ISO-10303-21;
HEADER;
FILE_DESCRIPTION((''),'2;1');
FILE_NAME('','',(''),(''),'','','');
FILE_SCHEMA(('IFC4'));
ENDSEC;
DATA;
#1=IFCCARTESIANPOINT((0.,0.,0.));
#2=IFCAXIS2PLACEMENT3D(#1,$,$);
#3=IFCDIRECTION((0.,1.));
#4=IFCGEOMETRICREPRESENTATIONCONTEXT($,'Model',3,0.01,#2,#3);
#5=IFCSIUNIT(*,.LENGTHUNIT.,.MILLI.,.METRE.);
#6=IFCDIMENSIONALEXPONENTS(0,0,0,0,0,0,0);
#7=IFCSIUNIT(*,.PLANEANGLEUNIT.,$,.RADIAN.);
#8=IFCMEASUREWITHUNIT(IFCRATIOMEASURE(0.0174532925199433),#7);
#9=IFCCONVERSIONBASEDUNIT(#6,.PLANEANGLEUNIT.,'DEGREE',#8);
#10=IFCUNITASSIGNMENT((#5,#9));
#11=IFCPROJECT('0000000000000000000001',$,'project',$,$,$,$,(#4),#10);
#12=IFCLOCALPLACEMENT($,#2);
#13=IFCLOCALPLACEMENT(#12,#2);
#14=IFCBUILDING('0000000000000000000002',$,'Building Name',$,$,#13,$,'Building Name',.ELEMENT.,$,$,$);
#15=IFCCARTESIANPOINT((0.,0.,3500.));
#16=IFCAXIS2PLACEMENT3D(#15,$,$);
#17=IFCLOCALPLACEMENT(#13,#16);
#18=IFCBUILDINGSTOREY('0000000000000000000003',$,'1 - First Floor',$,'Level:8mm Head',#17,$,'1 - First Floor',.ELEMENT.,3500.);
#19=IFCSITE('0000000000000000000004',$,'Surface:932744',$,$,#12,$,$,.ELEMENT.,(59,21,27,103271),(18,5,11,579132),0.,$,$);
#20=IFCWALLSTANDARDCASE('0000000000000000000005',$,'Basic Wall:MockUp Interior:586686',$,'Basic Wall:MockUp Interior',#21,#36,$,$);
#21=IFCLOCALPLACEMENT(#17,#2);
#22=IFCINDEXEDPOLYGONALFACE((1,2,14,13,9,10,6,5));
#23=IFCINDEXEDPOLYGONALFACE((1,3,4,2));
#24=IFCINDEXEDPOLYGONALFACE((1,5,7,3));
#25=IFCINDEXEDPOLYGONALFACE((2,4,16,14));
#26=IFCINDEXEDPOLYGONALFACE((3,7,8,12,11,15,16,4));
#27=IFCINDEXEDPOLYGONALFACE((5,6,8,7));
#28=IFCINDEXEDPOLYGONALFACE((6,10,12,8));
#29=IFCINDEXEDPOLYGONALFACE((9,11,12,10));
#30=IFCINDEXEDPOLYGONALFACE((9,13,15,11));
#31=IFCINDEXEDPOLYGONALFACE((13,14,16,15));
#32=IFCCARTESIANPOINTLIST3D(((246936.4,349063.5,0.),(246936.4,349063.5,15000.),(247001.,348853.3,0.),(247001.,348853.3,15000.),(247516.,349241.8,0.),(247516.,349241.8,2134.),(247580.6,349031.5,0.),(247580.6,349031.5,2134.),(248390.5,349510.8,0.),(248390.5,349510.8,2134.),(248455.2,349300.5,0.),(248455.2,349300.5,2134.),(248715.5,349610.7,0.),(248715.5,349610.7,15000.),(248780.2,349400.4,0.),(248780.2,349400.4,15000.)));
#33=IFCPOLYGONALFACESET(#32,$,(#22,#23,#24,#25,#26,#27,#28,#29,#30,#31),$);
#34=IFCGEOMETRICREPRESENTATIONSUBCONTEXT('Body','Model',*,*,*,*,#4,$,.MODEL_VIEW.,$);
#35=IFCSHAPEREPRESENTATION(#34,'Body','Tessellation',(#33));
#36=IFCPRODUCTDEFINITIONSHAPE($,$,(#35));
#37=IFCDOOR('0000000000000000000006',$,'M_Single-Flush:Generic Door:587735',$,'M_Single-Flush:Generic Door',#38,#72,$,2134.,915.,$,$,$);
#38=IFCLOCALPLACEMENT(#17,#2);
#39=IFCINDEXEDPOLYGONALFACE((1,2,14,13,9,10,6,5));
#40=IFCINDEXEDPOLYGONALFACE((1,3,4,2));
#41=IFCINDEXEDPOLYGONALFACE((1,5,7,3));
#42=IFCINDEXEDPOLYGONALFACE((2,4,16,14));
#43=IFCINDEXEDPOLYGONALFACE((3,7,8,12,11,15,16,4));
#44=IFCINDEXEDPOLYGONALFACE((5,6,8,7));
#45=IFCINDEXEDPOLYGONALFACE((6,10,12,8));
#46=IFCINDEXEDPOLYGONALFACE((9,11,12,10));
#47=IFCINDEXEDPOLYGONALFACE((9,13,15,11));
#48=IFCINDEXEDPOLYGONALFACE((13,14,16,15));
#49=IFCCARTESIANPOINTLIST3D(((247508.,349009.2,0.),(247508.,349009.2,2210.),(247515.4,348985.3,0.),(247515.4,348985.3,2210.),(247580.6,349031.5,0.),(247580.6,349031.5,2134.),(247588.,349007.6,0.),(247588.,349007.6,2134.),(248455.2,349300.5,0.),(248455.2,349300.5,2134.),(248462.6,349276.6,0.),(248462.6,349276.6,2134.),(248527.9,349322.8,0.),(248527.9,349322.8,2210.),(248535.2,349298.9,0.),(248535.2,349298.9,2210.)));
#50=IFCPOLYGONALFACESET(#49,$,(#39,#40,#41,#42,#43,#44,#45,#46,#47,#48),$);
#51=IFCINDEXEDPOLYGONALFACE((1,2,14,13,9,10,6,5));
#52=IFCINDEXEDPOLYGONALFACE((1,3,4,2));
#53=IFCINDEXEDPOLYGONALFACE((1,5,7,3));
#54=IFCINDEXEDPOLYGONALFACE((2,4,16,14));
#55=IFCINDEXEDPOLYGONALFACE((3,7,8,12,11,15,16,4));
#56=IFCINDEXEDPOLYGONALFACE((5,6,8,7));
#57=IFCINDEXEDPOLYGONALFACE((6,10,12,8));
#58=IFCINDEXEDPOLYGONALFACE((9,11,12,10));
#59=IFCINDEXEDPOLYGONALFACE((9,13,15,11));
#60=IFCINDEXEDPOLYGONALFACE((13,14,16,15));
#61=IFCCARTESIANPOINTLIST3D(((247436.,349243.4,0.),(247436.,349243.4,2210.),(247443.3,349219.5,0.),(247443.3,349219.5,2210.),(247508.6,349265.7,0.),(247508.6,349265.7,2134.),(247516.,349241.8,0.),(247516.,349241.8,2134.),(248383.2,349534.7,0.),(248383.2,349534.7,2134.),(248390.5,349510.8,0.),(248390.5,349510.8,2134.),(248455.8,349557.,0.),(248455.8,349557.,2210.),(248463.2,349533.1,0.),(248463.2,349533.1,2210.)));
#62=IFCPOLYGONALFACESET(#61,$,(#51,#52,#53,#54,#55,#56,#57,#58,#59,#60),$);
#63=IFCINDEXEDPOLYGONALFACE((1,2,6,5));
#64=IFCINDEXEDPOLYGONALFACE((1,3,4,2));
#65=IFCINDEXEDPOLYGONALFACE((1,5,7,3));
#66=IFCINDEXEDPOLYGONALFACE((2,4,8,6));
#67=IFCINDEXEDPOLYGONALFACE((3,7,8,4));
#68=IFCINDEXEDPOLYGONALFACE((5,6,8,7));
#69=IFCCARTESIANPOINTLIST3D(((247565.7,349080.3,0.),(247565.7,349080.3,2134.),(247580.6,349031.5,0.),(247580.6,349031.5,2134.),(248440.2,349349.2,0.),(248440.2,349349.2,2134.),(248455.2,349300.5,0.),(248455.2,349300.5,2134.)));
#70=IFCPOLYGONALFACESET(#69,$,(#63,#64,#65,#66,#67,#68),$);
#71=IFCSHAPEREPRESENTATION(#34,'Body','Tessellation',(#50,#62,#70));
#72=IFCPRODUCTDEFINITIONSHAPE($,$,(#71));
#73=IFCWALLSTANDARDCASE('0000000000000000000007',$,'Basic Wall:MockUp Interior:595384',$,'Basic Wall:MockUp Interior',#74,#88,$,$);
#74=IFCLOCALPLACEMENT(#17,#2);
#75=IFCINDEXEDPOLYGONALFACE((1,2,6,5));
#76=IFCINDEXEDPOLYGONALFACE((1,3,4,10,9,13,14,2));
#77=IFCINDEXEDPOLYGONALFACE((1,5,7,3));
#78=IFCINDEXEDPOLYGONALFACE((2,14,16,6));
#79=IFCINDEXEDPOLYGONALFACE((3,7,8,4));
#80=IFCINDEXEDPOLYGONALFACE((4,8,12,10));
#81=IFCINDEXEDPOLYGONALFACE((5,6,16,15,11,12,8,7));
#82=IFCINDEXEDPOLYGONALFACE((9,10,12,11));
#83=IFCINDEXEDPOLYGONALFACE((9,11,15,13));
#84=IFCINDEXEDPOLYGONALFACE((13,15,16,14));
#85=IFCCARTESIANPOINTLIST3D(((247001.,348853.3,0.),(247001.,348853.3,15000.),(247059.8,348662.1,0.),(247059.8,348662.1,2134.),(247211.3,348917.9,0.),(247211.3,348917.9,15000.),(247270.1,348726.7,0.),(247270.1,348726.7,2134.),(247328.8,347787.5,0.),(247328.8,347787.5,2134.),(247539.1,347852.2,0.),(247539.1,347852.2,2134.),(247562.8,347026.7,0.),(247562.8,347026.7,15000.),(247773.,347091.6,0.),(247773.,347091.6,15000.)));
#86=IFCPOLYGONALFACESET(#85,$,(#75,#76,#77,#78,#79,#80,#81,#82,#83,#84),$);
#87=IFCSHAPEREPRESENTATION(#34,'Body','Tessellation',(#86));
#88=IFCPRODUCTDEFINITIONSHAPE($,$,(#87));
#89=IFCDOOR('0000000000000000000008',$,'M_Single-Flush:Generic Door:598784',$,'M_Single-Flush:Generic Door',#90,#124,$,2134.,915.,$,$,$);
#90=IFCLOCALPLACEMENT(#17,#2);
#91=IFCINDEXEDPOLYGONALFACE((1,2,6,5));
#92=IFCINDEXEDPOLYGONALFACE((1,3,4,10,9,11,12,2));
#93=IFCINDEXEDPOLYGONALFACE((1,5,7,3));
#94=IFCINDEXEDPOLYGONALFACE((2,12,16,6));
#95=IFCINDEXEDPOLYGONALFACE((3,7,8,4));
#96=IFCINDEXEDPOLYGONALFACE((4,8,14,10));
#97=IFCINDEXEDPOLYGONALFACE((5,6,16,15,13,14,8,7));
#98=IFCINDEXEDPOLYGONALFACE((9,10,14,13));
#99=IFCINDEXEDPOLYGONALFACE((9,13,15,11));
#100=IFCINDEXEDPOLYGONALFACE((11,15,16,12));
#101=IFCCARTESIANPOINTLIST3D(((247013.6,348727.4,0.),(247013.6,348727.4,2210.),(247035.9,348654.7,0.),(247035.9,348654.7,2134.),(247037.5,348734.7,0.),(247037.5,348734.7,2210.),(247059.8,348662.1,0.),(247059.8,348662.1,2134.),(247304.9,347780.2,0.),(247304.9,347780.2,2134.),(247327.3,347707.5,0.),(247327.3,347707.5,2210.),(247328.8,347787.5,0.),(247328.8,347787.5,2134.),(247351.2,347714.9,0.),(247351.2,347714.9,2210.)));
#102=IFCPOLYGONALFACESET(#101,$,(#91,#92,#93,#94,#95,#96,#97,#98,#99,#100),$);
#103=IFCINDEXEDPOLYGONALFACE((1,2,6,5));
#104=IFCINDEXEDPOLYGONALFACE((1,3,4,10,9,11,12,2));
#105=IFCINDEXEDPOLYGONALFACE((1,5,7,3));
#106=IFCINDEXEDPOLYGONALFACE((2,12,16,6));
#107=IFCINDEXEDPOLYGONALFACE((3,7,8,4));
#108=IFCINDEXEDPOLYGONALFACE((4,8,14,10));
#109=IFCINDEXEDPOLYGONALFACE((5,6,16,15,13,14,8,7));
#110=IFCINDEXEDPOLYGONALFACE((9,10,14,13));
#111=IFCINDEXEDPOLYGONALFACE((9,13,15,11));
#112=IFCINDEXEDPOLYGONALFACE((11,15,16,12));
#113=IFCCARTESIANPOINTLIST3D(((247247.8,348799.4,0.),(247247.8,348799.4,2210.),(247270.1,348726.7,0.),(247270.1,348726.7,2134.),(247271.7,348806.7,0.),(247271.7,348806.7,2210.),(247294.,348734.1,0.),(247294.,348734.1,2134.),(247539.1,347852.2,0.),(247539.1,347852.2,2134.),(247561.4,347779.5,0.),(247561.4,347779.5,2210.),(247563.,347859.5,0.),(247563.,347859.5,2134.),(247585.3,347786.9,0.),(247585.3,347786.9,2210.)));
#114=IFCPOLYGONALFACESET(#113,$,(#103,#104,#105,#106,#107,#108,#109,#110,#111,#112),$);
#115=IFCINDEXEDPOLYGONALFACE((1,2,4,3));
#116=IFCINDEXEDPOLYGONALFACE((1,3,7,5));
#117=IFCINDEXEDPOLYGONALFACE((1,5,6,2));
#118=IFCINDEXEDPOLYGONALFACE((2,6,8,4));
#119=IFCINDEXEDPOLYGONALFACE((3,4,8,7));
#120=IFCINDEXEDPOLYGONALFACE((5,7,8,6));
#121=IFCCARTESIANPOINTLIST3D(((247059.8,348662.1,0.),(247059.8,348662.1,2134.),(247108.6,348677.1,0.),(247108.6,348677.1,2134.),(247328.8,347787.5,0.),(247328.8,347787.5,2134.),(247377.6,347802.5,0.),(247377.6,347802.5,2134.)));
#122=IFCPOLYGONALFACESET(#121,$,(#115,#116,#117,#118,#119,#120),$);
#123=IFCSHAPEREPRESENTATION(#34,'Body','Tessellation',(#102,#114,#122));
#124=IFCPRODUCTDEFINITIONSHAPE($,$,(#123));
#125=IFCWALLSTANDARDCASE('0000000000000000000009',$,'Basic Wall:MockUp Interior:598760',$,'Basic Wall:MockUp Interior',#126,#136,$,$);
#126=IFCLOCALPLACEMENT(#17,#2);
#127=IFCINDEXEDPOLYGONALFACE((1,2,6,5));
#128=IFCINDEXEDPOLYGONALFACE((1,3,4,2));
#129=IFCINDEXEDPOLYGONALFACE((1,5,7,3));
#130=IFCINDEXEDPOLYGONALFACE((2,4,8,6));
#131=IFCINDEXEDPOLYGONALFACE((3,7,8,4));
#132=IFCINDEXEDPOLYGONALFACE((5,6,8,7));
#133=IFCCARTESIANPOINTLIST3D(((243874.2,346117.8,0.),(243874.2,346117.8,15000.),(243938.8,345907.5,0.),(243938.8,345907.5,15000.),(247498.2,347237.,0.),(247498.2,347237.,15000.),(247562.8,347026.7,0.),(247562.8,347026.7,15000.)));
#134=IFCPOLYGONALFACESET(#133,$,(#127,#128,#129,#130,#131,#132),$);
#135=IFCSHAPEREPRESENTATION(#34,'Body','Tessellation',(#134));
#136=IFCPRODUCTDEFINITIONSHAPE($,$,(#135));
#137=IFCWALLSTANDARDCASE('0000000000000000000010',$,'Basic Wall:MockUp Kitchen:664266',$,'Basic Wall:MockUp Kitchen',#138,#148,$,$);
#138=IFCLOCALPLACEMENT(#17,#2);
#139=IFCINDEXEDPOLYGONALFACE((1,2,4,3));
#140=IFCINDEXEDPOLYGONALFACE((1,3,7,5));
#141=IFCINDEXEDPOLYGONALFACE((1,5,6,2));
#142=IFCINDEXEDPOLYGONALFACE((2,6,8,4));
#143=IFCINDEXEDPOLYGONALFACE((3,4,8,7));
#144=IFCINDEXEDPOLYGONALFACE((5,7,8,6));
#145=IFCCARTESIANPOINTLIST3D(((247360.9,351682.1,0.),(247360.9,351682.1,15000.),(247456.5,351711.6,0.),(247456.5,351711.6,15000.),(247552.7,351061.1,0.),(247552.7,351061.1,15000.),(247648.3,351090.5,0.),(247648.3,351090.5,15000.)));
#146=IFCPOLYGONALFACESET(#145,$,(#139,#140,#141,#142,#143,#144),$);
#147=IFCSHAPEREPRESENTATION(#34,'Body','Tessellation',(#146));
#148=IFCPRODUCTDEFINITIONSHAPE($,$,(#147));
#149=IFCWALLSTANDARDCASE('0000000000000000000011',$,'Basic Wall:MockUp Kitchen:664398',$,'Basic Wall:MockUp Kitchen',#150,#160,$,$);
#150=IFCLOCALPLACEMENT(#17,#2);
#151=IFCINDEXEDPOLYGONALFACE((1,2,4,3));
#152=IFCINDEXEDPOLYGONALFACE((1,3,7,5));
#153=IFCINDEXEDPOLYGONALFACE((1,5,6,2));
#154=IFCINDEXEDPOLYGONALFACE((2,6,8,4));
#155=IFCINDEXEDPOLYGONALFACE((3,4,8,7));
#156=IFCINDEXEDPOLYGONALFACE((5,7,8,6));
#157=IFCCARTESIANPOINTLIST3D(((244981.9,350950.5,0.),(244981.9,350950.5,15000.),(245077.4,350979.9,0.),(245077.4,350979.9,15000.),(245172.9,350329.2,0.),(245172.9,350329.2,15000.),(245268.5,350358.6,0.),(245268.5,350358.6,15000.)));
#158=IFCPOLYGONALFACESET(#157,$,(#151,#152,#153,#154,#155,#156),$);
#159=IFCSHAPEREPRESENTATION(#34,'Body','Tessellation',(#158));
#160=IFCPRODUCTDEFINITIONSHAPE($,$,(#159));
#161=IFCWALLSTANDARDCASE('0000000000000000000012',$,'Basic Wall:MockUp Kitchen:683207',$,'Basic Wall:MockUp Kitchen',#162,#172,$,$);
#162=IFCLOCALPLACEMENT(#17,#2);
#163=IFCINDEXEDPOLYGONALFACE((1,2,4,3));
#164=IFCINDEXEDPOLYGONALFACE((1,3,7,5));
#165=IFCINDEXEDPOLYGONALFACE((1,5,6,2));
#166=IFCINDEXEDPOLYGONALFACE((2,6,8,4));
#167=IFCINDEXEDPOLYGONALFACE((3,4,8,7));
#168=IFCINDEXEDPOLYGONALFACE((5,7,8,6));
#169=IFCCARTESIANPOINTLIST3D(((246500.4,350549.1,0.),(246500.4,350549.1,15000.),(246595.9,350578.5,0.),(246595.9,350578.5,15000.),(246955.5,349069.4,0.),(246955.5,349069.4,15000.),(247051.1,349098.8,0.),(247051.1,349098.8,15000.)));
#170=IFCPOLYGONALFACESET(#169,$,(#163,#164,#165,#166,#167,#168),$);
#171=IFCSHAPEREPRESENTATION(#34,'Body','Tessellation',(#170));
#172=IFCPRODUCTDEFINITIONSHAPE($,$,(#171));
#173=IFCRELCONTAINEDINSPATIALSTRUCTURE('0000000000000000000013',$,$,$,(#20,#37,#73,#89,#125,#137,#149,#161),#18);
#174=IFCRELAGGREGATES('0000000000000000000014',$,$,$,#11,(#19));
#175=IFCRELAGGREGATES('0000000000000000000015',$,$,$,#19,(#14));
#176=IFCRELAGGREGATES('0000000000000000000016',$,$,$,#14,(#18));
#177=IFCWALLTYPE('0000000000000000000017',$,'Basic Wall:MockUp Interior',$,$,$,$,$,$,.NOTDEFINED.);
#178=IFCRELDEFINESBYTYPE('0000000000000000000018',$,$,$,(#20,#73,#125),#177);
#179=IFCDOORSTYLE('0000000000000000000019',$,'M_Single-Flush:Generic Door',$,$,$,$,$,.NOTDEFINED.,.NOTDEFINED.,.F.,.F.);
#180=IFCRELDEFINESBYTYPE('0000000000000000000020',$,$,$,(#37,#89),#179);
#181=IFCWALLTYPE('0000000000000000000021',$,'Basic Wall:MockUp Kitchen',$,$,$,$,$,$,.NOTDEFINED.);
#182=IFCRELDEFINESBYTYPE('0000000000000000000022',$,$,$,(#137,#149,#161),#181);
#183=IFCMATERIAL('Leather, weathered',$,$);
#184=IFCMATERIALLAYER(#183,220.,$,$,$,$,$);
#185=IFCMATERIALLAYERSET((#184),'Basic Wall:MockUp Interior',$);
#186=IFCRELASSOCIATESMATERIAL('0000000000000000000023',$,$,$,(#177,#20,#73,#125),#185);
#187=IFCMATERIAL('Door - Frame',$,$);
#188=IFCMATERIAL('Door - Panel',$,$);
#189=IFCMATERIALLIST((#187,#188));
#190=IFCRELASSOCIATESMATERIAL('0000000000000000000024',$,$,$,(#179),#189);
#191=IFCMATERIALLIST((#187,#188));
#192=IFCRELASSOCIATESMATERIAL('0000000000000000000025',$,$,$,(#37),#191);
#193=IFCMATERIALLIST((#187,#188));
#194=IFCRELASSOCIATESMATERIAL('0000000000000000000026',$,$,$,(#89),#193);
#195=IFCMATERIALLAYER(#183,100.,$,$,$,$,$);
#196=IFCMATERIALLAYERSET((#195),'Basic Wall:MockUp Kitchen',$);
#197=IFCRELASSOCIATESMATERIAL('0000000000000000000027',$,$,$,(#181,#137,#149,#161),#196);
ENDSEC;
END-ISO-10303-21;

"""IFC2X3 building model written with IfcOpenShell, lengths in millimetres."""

from ifc_helpers import new_model, entity, si_unit, converted_unit, direction, frame, frame_2d, origin, place, context, subcontext, project, spatial, polyline, rectangle, outline, extrude, source, transform, mapped, material, material_list, layer, layer_set, layer_usage, type_object, type_shapes, element, fill, save


model = new_model("IFC2X3")

# Units and contexts
model_context = context("Model", 3, precision=0.01, world=origin(), true_north=direction((0.0, 1.0)))
body_context = subcontext(model_context, "Body", "Model", "MODEL_VIEW")
ifc_project = project(units=[si_unit("LENGTHUNIT", "METRE", prefix="MILLI"), converted_unit("PLANEANGLEUNIT", "DEGREE", entity("IfcRatioMeasure", 0.0174532925199433), si_unit("PLANEANGLEUNIT", "RADIAN"), dimensions=[0, 0, 0, 0, 0, 0, 0])], contexts=[model_context])

# Site, building, storey
site_placement = place(None, origin())
site = spatial("IfcSite", under=ifc_project, at=site_placement, Name="Surface:932744", CompositionType="ELEMENT", RefLatitude=(59, 21, 27, 103271), RefLongitude=(18, 5, 11, 579132), RefElevation=0.0)
building_placement = place(site_placement, origin())
building = spatial("IfcBuilding", under=site, at=building_placement, Name="Building Name", LongName="Building Name", CompositionType="ELEMENT")
storey_placement = place(building_placement, frame((0.0, 0.0, 3500.0)))
storey = spatial("IfcBuildingStorey", under=building, at=storey_placement, Name="1 - First Floor", ObjectType="Level:8mm Head", LongName="1 - First Floor", CompositionType="ELEMENT", Elevation=3500.0)

# Walls, openings, doors
ifc_material_1 = material(Name="Leather, weathered")
ifc_layer_1 = layer(ifc_material_1, 220.0)
ifc_layer_set_1 = layer_set([ifc_layer_1], Name="Basic Wall:MockUp Interior")
ifc_layer_usage_1 = layer_usage(ifc_layer_set_1, "AXIS2", "NEGATIVE", 110.0)
wall_type_1 = type_object("IfcWallType", Name="Basic Wall:MockUp Interior", PredefinedType="NOTDEFINED", material=ifc_layer_set_1)
wall_1_placement = place(storey_placement, frame((246968.7, 348958.4, 0.0), z_axis=(0.0, 0.0, 1.0), x_axis=(0.955818, 0.293958, 0.0)))
wall_1 = element("IfcWallStandardCase", 1, at=wall_1_placement, inside=storey, type_object=wall_type_1, material=ifc_layer_usage_1, Name="Basic Wall:MockUp Interior:586686", ObjectType="Basic Wall:MockUp Interior", context=body_context, shape_type="SweptSolid", body=[
    extrude(rectangle(XDim=1861.4, YDim=220.0, at=frame_2d((930.7, 0.0), x_axis=(-1.0, 0.0))), origin(), (0.0, 0.0, 1.0), 15000.0),
])
opening_1_placement = place(wall_1_placement, frame((1521.4, 110.0, 0.0)))
opening_1 = element("IfcOpeningElement", 2, at=opening_1_placement, cuts=wall_1, ObjectType="Opening", context=body_context, shape_type="SweptSolid", body=[
    extrude(rectangle(XDim=915.0, YDim=2134.0, at=frame_2d((1067.0, 457.5), x_axis=(0.0, -1.0))), frame((0.0, 0.0, 0.0), z_axis=(0.0, -1.0, 0.0), x_axis=(0.0, 0.0, 1.0)), (0.0, 0.0, 1.0), 220.0),
])
ifc_material_2 = material(Name="Door - Frame")
ifc_material_3 = material(Name="Door - Panel")
ifc_material_list_1 = material_list([ifc_material_2, ifc_material_3])
ifc_material_list_2 = material_list([ifc_material_2, ifc_material_3])
door_style = type_object("IfcDoorStyle", Name="M_Single-Flush:Generic Door", ConstructionType="NOTDEFINED", OperationType="NOTDEFINED", ParameterTakesPrecedence=False, Sizeable=False, material=ifc_material_list_2)
shared_shape_1 = source(origin(), body_context, "Body", "SweptSolid", [
    extrude(outline(polyline([(-533.5, -1124.0), (533.5, -1124.0), (533.5, 1086.0), (457.5, 1086.0), (457.5, -1048.0), (-457.5, -1048.0), (-457.5, 1086.0), (-533.5, 1086.0), (-533.5, -1124.0)])), frame((457.5, 245.0, 1086.0), z_axis=(0.0, -1.0, 0.0), x_axis=(-1.0, 0.0, 0.0)), (0.0, 0.0, 1.0), 25.0),
    extrude(outline(polyline([(-1124.0, -533.5), (1086.0, -533.5), (1086.0, -457.5), (-1048.0, -457.5), (-1048.0, 457.5), (1086.0, 457.5), (1086.0, 533.5), (-1124.0, 533.5), (-1124.0, -533.5)])), frame((457.5, 0.0, 1086.0), z_axis=(0.0, -1.0, 0.0), x_axis=(0.0, 0.0, -1.0)), (0.0, 0.0, 1.0), 25.0),
    extrude(rectangle(XDim=915.0, YDim=51.0, at=frame_2d((0.0, 0.0), x_axis=(1.0, 0.0))), frame((457.5, 194.5, 0.0)), (0.0, 0.0, 1.0), 2134.0),
])
type_shapes(door_style, [shared_shape_1])
door_1_placement = place(opening_1_placement, frame((0.0, 0.0, 0.0), z_axis=(0.0, 0.0, 1.0), x_axis=(-1.0, 0.0, 0.0)))
door_1 = element("IfcDoor", 3, at=door_1_placement, inside=storey, type_object=door_style, material=ifc_material_list_1, Name="M_Single-Flush:Generic Door:587735", ObjectType="M_Single-Flush:Generic Door", OverallHeight=2134.0, OverallWidth=915.0, context=body_context, shape_type="MappedRepresentation", body=[
    mapped(shared_shape_1, transform((0.0, 0.0, 0.0), scale=1.0)),
])
fill(opening_1, door_1)
ifc_layer_usage_2 = layer_usage(ifc_layer_set_1, "AXIS2", "NEGATIVE", 110.0)
wall_2_placement = place(storey_placement, frame((247668.0, 347059.0, 0.0), z_axis=(0.0, 0.0, 1.0), x_axis=(-0.29398, 0.955811, 0.0)))
wall_2 = element("IfcWallStandardCase", 4, at=wall_2_placement, inside=storey, type_object=wall_type_1, material=ifc_layer_usage_2, Name="Basic Wall:MockUp Interior:595384", ObjectType="Basic Wall:MockUp Interior", context=body_context, shape_type="SweptSolid", body=[
    extrude(outline(polyline([(0.3, -110.0), (1911.0, -110.0), (1911.0, 110.0), (220.0, 110.0), (0.0, 110.0), (0.3, -110.0)])), origin(), (0.0, 0.0, 1.0), 15000.0),
])
opening_2_placement = place(wall_2_placement, frame((796.0, -110.0, 0.0)))
opening_2 = element("IfcOpeningElement", 5, at=opening_2_placement, cuts=wall_2, ObjectType="Opening", context=body_context, shape_type="SweptSolid", body=[
    extrude(rectangle(XDim=915.0, YDim=2134.0, at=frame_2d((1067.0, 457.5), x_axis=(0.0, -1.0))), frame((0.0, 0.0, 0.0), z_axis=(0.0, 1.0, 0.0), x_axis=(0.0, 0.0, 1.0)), (0.0, 0.0, 1.0), 220.0),
])
ifc_material_list_3 = material_list([ifc_material_2, ifc_material_3])
door_2_placement = place(opening_2_placement, origin())
door_2 = element("IfcDoor", 6, at=door_2_placement, inside=storey, type_object=door_style, material=ifc_material_list_3, Name="M_Single-Flush:Generic Door:598784", ObjectType="M_Single-Flush:Generic Door", OverallHeight=2134.0, OverallWidth=915.0, context=body_context, shape_type="MappedRepresentation", body=[
    mapped(shared_shape_1, transform((0.0, 0.0, 0.0), scale=1.0)),
])
fill(opening_2, door_2)

# Walls
ifc_layer_usage_3 = layer_usage(ifc_layer_set_1, "AXIS2", "NEGATIVE", 110.0)
wall_3_placement = place(storey_placement, frame((247530.6, 347131.9, 0.0), z_axis=(0.0, 0.0, 1.0), x_axis=(-0.955473, -0.29508, 0.0)))
element("IfcWallStandardCase", 7, at=wall_3_placement, inside=storey, type_object=wall_type_1, material=ifc_layer_usage_3, Name="Basic Wall:MockUp Interior:598760", ObjectType="Basic Wall:MockUp Interior", context=body_context, shape_type="SweptSolid", body=[
    extrude(outline(polyline([(3792.9, -110.0), (3793.1, 110.0), (0.3, 110.0), (0.0, -110.0), (3792.9, -110.0)])), origin(), (0.0, 0.0, 1.0), 15000.0),
])
ifc_layer_2 = layer(ifc_material_1, 100.0)
ifc_layer_set_2 = layer_set([ifc_layer_2], Name="Basic Wall:MockUp Kitchen")
ifc_layer_usage_4 = layer_usage(ifc_layer_set_2, "AXIS2", "NEGATIVE", 50.0)
wall_type_2 = type_object("IfcWallType", Name="Basic Wall:MockUp Kitchen", PredefinedType="NOTDEFINED", material=ifc_layer_set_2)
wall_4_placement = place(storey_placement, frame((247600.5, 351075.7, 0.0), z_axis=(0.0, 0.0, 1.0), x_axis=(-0.29508, 0.955473, 0.0)))
element("IfcWallStandardCase", 8, at=wall_4_placement, inside=storey, type_object=wall_type_2, material=ifc_layer_usage_4, Name="Basic Wall:MockUp Kitchen:664266", ObjectType="Basic Wall:MockUp Kitchen", context=body_context, shape_type="SweptSolid", body=[
    extrude(outline(polyline([(650.1, -50.0), (650.1, 50.0), (0.1, 50.0), (0.0, -50.0), (650.1, -50.0)])), origin(), (0.0, 0.0, 1.0), 15000.0),
])
ifc_layer_usage_5 = layer_usage(ifc_layer_set_2, "AXIS2", "NEGATIVE", 50.0)
wall_5_placement = place(storey_placement, frame((245220.7, 350343.9, 0.0), z_axis=(0.0, 0.0, 1.0), x_axis=(-0.293958, 0.955818, 0.0)))
element("IfcWallStandardCase", 9, at=wall_5_placement, inside=storey, type_object=wall_type_2, material=ifc_layer_usage_5, Name="Basic Wall:MockUp Kitchen:664398", ObjectType="Basic Wall:MockUp Kitchen", context=body_context, shape_type="SweptSolid", body=[
    extrude(rectangle(XDim=650.0, YDim=100.0, at=frame_2d((325.0, 0.0), x_axis=(-1.0, 0.0))), origin(), (0.0, 0.0, 1.0), 15000.0),
])
ifc_layer_usage_6 = layer_usage(ifc_layer_set_2, "AXIS2", "NEGATIVE", 50.0)
wall_6_placement = place(storey_placement, frame((247003.3, 349084.1, 0.0), z_axis=(0.0, 0.0, 1.0), x_axis=(-0.29398, 0.955811, 0.0)))
element("IfcWallStandardCase", 10, at=wall_6_placement, inside=storey, type_object=wall_type_2, material=ifc_layer_usage_6, Name="Basic Wall:MockUp Kitchen:683207", ObjectType="Basic Wall:MockUp Kitchen", context=body_context, shape_type="SweptSolid", body=[
    extrude(rectangle(XDim=1548.1, YDim=100.0, at=frame_2d((774.1, 0.0), x_axis=(-1.0, 0.0))), origin(), (0.0, 0.0, 1.0), 15000.0),
])

save(model, "model.ifc")
